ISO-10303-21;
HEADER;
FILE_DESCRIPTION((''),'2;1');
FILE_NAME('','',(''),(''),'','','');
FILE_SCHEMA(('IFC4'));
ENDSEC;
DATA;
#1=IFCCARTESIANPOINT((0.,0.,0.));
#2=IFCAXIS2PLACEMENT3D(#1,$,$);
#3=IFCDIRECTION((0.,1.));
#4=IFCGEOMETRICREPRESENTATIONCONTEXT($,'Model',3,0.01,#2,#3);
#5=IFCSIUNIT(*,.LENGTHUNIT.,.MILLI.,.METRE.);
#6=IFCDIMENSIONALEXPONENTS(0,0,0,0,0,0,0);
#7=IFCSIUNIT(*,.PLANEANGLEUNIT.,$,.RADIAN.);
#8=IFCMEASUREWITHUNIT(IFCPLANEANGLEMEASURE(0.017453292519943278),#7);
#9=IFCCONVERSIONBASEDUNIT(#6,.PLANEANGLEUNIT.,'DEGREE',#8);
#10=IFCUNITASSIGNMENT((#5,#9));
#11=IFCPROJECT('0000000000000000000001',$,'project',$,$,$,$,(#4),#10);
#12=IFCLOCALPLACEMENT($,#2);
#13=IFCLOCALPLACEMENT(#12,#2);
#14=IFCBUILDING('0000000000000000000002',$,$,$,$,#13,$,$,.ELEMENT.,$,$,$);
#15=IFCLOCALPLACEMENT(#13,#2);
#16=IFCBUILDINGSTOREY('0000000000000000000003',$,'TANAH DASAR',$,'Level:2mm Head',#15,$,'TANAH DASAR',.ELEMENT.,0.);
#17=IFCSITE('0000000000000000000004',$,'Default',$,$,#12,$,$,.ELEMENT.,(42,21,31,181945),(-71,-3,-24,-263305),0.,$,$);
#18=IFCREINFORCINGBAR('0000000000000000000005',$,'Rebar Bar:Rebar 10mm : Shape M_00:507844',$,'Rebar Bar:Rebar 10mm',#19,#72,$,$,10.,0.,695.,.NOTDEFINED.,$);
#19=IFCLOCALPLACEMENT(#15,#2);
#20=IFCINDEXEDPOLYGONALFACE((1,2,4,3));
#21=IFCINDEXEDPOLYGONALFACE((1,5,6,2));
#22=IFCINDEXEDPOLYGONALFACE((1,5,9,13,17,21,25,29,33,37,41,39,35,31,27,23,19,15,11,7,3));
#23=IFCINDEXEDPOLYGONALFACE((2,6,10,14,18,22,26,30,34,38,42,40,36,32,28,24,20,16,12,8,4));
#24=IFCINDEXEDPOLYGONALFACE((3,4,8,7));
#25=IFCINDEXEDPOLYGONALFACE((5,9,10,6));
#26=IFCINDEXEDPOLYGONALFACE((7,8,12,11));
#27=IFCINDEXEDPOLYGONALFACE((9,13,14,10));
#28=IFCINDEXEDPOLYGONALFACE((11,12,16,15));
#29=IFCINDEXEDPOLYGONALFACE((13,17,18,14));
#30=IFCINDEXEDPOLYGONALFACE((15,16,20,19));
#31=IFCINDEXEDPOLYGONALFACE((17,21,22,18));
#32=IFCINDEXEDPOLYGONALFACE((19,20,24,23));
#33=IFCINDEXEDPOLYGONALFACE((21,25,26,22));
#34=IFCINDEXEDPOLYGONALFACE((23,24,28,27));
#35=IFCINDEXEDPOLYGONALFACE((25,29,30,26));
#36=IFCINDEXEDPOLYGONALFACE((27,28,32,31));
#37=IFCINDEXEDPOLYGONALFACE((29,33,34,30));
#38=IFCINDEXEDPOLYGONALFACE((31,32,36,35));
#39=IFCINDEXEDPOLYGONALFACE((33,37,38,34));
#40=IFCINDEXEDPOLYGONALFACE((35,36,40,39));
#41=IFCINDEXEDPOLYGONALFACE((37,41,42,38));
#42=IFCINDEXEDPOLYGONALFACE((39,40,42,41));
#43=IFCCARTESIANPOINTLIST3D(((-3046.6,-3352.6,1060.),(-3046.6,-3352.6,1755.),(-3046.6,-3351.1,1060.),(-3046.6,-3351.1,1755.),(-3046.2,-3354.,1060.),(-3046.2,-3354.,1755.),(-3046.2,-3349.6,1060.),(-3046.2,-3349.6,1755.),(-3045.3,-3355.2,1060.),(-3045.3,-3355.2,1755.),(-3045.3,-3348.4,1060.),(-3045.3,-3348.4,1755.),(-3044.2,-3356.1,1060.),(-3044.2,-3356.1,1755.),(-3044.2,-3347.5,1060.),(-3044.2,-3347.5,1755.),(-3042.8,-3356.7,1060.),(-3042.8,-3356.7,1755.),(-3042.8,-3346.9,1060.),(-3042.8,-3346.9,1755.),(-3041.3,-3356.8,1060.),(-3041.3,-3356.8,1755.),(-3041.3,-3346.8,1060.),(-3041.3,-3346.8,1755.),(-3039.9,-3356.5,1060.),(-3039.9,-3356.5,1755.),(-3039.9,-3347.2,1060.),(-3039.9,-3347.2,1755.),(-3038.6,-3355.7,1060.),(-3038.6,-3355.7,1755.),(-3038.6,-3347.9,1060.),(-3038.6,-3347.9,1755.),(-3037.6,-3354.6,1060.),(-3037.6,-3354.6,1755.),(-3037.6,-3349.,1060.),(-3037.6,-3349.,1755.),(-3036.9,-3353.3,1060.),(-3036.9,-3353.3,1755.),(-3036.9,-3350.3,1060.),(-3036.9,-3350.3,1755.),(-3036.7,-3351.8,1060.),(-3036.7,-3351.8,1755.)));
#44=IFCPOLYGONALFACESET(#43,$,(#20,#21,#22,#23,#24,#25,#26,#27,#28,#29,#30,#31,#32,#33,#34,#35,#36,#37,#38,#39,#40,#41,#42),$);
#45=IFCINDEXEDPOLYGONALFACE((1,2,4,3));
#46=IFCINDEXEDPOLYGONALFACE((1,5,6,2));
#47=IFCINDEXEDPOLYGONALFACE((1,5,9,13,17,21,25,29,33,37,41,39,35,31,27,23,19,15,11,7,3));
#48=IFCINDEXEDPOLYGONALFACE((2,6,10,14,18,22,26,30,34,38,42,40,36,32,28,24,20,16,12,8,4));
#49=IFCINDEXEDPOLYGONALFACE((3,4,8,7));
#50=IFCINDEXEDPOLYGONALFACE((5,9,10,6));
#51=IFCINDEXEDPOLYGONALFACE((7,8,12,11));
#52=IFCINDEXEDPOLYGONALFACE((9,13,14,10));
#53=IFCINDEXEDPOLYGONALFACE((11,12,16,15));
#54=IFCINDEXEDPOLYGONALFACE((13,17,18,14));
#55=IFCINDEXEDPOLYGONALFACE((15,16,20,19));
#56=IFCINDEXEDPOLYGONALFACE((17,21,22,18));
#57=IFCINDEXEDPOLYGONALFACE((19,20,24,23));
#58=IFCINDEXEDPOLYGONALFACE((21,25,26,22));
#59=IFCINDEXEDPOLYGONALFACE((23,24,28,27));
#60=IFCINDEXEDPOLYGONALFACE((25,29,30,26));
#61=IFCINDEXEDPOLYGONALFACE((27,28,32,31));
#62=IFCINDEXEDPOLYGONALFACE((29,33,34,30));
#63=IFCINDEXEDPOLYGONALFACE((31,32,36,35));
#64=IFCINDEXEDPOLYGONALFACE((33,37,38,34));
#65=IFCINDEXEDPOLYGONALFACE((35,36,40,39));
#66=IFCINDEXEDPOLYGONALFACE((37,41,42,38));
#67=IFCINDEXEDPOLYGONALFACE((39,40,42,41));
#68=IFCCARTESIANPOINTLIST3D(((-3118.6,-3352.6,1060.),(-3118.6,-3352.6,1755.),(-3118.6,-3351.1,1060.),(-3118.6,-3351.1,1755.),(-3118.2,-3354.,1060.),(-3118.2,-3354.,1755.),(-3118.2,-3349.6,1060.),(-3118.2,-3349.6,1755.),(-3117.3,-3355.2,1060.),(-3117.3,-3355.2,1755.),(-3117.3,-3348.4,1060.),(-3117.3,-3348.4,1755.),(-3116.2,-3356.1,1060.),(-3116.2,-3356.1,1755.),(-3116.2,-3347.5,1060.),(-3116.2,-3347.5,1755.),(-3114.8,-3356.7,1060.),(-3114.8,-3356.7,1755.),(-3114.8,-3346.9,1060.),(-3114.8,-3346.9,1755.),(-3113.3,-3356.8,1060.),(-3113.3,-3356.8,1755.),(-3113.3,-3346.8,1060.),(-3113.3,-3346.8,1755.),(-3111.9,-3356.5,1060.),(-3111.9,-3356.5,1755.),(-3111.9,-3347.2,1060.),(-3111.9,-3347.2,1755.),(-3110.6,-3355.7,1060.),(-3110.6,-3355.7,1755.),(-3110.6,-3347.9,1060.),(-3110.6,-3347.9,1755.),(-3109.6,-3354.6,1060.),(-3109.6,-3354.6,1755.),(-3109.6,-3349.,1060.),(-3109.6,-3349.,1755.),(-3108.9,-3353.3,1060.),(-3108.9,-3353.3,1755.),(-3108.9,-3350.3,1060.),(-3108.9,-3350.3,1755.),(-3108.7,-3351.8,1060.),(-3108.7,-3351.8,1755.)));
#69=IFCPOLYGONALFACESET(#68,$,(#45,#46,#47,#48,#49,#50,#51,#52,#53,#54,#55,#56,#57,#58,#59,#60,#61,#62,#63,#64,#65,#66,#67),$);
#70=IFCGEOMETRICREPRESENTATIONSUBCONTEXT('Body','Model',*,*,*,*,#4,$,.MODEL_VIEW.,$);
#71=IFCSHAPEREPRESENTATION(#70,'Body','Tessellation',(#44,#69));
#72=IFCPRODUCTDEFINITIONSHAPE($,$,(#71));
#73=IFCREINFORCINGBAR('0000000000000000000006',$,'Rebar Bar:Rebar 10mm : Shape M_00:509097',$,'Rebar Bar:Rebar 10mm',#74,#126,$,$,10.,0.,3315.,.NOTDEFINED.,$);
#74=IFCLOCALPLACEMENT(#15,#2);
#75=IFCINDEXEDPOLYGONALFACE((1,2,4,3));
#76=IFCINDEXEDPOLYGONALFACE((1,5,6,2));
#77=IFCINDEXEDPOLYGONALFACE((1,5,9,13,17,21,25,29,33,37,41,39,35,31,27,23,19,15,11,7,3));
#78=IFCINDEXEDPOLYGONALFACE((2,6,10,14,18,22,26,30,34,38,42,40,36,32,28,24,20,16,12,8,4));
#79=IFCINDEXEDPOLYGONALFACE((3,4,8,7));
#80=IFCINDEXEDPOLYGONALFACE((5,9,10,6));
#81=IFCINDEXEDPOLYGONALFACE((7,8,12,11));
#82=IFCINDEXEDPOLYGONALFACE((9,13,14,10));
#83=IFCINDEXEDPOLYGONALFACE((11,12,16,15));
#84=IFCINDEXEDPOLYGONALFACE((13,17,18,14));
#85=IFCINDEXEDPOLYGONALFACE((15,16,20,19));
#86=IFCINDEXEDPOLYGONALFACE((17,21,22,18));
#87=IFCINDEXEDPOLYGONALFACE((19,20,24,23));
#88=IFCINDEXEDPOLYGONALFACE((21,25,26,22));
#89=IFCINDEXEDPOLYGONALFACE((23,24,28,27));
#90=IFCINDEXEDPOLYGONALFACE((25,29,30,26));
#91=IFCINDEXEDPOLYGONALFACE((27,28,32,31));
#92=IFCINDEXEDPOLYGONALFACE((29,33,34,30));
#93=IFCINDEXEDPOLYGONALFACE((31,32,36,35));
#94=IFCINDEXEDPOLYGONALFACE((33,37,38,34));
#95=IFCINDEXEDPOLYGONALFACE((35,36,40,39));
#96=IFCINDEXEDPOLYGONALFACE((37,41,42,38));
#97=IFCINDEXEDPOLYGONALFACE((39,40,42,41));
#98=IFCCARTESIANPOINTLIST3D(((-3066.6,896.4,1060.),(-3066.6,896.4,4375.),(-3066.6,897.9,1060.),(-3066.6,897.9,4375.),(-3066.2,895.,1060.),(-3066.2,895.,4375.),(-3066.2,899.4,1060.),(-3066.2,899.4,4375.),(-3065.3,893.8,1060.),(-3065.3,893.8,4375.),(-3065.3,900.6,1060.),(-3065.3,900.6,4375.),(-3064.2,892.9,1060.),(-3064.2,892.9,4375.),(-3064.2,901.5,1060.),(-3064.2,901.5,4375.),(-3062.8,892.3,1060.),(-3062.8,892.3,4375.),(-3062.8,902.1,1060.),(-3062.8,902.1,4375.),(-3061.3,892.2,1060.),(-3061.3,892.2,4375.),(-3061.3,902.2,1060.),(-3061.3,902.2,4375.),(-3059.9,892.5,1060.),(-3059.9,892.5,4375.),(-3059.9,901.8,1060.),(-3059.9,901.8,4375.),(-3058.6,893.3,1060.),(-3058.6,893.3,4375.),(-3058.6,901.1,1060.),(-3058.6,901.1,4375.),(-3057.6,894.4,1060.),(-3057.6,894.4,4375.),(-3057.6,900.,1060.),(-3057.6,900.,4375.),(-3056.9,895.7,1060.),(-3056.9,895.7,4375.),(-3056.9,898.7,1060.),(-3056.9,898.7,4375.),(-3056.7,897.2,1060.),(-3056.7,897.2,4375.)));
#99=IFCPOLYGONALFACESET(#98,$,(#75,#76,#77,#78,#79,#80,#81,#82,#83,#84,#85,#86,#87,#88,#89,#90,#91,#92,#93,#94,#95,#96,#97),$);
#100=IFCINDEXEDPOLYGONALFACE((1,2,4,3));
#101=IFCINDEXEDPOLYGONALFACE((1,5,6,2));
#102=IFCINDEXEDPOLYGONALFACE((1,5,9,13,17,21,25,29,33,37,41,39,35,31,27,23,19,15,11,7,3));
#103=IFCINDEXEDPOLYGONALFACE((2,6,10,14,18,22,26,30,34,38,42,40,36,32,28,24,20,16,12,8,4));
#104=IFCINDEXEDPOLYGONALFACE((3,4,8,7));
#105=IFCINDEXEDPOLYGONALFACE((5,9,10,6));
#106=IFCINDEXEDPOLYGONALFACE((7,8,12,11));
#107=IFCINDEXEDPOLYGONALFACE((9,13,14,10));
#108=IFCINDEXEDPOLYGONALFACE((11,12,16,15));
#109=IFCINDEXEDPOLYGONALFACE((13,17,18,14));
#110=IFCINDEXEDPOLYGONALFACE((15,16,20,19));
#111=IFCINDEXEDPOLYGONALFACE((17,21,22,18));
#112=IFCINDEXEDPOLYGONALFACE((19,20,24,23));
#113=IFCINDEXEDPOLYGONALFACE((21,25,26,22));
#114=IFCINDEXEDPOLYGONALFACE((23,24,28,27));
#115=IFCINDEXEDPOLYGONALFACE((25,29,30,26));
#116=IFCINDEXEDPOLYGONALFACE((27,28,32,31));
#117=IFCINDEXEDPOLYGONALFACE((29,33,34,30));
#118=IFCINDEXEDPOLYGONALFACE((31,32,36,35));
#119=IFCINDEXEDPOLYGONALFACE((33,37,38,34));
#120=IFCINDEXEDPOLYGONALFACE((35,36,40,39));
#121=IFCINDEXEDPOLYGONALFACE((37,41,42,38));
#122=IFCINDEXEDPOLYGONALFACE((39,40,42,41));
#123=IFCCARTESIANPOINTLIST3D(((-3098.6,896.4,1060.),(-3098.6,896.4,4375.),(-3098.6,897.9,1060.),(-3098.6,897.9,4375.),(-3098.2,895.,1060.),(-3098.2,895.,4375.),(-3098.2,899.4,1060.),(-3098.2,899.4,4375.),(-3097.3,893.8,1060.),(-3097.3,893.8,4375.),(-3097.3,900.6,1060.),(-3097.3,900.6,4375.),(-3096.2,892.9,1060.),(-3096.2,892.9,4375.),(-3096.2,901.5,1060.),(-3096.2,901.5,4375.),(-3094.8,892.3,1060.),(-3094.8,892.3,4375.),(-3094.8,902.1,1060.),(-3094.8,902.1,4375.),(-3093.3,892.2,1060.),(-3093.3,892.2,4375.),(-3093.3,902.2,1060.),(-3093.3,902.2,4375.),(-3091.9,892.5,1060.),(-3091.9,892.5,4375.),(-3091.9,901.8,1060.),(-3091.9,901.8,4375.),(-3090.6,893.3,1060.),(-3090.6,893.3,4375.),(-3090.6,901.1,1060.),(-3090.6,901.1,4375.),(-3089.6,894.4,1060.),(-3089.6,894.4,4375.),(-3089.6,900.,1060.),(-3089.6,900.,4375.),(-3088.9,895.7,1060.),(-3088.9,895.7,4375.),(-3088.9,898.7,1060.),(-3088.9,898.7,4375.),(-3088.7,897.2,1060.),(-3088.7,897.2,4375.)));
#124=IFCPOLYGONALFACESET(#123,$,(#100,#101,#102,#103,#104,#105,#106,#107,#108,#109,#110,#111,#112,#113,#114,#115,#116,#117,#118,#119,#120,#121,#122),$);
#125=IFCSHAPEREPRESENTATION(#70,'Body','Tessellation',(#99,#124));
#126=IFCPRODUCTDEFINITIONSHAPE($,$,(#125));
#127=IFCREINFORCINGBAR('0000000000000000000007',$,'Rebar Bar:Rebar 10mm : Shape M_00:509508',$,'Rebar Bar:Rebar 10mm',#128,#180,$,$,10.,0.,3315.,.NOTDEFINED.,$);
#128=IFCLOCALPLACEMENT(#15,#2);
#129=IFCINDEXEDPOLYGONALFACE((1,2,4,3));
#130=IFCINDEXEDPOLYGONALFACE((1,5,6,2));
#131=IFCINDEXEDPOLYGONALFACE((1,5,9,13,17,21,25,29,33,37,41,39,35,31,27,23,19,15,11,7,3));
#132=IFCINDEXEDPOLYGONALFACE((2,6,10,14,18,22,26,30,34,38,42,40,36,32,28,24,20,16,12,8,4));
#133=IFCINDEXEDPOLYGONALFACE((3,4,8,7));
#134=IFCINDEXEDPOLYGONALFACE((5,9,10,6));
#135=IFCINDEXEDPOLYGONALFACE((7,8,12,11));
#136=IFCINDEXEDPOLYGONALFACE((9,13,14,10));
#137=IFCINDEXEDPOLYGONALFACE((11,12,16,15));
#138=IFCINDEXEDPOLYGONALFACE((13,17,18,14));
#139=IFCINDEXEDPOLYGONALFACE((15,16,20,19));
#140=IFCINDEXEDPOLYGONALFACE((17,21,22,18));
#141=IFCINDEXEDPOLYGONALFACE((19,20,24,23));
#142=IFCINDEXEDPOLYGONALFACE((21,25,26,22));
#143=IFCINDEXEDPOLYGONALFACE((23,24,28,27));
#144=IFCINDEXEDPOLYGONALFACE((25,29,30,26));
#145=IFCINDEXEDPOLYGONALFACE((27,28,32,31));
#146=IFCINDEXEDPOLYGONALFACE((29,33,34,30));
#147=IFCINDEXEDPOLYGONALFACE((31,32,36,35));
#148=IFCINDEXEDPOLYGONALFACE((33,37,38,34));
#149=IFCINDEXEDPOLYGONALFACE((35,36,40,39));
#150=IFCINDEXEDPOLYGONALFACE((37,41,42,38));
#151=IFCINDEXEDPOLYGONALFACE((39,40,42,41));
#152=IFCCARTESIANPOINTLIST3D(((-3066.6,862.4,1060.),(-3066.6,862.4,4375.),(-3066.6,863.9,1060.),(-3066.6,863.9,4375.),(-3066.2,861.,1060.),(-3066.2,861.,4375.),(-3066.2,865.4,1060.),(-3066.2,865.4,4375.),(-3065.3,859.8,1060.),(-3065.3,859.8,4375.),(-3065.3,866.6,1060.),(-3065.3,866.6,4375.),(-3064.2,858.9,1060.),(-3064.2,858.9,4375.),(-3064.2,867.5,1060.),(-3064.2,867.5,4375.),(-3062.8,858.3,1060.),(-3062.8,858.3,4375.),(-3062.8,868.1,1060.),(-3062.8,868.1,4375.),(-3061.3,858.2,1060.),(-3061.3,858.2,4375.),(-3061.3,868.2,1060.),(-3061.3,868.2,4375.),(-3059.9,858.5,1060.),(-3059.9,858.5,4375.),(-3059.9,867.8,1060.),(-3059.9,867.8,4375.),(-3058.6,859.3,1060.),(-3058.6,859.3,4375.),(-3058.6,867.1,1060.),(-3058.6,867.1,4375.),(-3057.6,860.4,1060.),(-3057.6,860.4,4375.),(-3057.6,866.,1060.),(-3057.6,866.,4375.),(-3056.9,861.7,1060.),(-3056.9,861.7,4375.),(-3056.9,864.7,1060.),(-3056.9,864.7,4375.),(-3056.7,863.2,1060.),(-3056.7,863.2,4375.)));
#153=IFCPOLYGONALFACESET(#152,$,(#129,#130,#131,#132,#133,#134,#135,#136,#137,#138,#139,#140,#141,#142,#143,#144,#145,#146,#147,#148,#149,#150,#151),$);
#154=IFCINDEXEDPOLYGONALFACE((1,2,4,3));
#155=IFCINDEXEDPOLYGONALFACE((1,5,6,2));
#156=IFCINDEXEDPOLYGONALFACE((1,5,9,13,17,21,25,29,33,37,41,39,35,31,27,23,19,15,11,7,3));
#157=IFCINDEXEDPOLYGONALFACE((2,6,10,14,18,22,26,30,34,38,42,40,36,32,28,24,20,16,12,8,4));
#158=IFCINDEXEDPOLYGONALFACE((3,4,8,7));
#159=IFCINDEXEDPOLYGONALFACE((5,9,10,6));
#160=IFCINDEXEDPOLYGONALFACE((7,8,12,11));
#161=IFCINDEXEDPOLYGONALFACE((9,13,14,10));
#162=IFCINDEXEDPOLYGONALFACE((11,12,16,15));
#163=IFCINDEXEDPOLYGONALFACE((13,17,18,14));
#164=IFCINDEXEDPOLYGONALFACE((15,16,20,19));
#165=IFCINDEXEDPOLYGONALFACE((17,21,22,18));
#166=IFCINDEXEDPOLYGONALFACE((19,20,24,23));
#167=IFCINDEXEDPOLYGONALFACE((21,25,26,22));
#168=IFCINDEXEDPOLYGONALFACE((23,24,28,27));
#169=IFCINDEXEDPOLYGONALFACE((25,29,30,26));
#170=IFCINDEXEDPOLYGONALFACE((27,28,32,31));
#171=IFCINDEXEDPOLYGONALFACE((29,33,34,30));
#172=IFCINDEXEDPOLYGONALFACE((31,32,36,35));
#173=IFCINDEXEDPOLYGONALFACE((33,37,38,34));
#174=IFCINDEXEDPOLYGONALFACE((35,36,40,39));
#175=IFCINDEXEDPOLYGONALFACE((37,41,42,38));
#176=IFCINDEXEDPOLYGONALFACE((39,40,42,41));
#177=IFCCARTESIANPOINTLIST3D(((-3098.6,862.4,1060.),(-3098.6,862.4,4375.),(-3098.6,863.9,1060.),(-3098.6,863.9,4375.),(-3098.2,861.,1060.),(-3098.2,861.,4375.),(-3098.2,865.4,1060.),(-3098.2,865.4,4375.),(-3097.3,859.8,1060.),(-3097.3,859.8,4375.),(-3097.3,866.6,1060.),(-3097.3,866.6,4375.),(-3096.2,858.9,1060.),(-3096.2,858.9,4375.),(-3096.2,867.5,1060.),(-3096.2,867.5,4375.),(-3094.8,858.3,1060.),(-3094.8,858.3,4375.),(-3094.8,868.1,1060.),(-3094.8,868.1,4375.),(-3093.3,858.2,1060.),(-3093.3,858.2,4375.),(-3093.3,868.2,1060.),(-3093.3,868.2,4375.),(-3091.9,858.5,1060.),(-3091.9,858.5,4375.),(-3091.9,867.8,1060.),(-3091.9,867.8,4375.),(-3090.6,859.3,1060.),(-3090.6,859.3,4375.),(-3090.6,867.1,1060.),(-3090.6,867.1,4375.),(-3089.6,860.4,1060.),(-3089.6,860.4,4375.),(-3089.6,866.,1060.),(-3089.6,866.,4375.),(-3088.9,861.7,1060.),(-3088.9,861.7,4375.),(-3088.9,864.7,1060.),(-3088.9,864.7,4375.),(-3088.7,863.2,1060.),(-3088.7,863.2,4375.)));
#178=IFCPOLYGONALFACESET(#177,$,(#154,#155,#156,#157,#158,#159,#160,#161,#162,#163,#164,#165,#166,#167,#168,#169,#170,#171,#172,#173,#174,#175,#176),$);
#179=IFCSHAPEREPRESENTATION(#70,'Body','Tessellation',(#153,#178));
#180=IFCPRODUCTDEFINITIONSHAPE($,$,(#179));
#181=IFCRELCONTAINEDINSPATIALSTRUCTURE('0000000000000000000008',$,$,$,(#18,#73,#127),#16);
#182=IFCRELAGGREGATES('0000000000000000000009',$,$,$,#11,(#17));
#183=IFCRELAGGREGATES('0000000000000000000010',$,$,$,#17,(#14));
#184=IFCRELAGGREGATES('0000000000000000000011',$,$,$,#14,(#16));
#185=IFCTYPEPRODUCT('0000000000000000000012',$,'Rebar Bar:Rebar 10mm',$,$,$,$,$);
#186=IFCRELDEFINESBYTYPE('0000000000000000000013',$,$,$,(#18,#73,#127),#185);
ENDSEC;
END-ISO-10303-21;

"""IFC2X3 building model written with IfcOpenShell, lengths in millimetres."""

from ifc_helpers import new_model, entity, si_unit, converted_unit, direction, origin, place, context, subcontext, project, spatial, type_object, element, save


model = new_model("IFC2X3")

# Units and contexts
model_context = context("Model", 3, precision=0.01, world=origin(), true_north=direction((0.0, 1.0)))
body_context = subcontext(model_context, "Body", "Model", "MODEL_VIEW")
ifc_project = project(units=[si_unit("LENGTHUNIT", "METRE", prefix="MILLI"), converted_unit("PLANEANGLEUNIT", "DEGREE", entity("IfcPlaneAngleMeasure", 0.017453292519943278), si_unit("PLANEANGLEUNIT", "RADIAN"), dimensions=[0, 0, 0, 0, 0, 0, 0])], contexts=[model_context])

# Site, building, storey
site_placement = place(None, origin())
site = spatial("IfcSite", under=ifc_project, at=site_placement, Name="Default", CompositionType="ELEMENT", RefLatitude=(42, 21, 31, 181945), RefLongitude=(-71, -3, -24, -263305), RefElevation=0.0)
building_placement = place(site_placement, origin())
building = spatial("IfcBuilding", under=site, at=building_placement, CompositionType="ELEMENT")
storey_placement = place(building_placement, origin())
storey = spatial("IfcBuildingStorey", under=building, at=storey_placement, Name="TANAH DASAR", ObjectType="Level:2mm Head", LongName="TANAH DASAR", CompositionType="ELEMENT", Elevation=0.0)

# Reinforcing bars
type_product_1 = type_object("IfcTypeProduct", Name="Rebar Bar:Rebar 10mm")
reinforcing_bar_1_placement = place(storey_placement, origin())
element("IfcReinforcingBar", 1, at=reinforcing_bar_1_placement, inside=storey, type_object=type_product_1, Name="Rebar Bar:Rebar 10mm : Shape M_00:507844", ObjectType="Rebar Bar:Rebar 10mm", BarLength=695.0, BarRole="NOTDEFINED", CrossSectionArea=0.0, NominalDiameter=10.0, context=body_context, shape_type="AdvancedSweptSolid", body=[
    entity("IfcSweptDiskSolid", entity("IfcCompositeCurve", [entity("IfcCompositeCurveSegment", "CONTINUOUS", True, entity("IfcPolyline", [entity("IfcCartesianPoint", [-3041.7, -3351.8, 1060.0]), entity("IfcCartesianPoint", [-3041.7, -3351.8, 1755.0])]))], False), 5.0, None, 0.0, 1.0),
    entity("IfcSweptDiskSolid", entity("IfcCompositeCurve", [entity("IfcCompositeCurveSegment", "CONTINUOUS", True, entity("IfcPolyline", [entity("IfcCartesianPoint", [-3113.7, -3351.8, 1060.0]), entity("IfcCartesianPoint", [-3113.7, -3351.8, 1755.0])]))], False), 5.0, None, 0.0, 1.0),
])
reinforcing_bar_2_placement = place(storey_placement, origin())
element("IfcReinforcingBar", 2, at=reinforcing_bar_2_placement, inside=storey, type_object=type_product_1, Name="Rebar Bar:Rebar 10mm : Shape M_00:509097", ObjectType="Rebar Bar:Rebar 10mm", BarLength=3315.0, BarRole="NOTDEFINED", CrossSectionArea=0.0, NominalDiameter=10.0, context=body_context, shape_type="AdvancedSweptSolid", body=[
    entity("IfcSweptDiskSolid", entity("IfcCompositeCurve", [entity("IfcCompositeCurveSegment", "CONTINUOUS", True, entity("IfcPolyline", [entity("IfcCartesianPoint", [-3061.7, 897.2, 1060.0]), entity("IfcCartesianPoint", [-3061.7, 897.2, 4375.0])]))], False), 5.0, None, 0.0, 1.0),
    entity("IfcSweptDiskSolid", entity("IfcCompositeCurve", [entity("IfcCompositeCurveSegment", "CONTINUOUS", True, entity("IfcPolyline", [entity("IfcCartesianPoint", [-3093.7, 897.2, 1060.0]), entity("IfcCartesianPoint", [-3093.7, 897.2, 4375.0])]))], False), 5.0, None, 0.0, 1.0),
])
reinforcing_bar_3_placement = place(storey_placement, origin())
element("IfcReinforcingBar", 3, at=reinforcing_bar_3_placement, inside=storey, type_object=type_product_1, Name="Rebar Bar:Rebar 10mm : Shape M_00:509508", ObjectType="Rebar Bar:Rebar 10mm", BarLength=3315.0, BarRole="NOTDEFINED", CrossSectionArea=0.0, NominalDiameter=10.0, context=body_context, shape_type="AdvancedSweptSolid", body=[
    entity("IfcSweptDiskSolid", entity("IfcCompositeCurve", [entity("IfcCompositeCurveSegment", "CONTINUOUS", True, entity("IfcPolyline", [entity("IfcCartesianPoint", [-3061.7, 863.2, 1060.0]), entity("IfcCartesianPoint", [-3061.7, 863.2, 4375.0])]))], False), 5.0, None, 0.0, 1.0),
    entity("IfcSweptDiskSolid", entity("IfcCompositeCurve", [entity("IfcCompositeCurveSegment", "CONTINUOUS", True, entity("IfcPolyline", [entity("IfcCartesianPoint", [-3093.7, 863.2, 1060.0]), entity("IfcCartesianPoint", [-3093.7, 863.2, 4375.0])]))], False), 5.0, None, 0.0, 1.0),
])

save(model, "model.ifc")
